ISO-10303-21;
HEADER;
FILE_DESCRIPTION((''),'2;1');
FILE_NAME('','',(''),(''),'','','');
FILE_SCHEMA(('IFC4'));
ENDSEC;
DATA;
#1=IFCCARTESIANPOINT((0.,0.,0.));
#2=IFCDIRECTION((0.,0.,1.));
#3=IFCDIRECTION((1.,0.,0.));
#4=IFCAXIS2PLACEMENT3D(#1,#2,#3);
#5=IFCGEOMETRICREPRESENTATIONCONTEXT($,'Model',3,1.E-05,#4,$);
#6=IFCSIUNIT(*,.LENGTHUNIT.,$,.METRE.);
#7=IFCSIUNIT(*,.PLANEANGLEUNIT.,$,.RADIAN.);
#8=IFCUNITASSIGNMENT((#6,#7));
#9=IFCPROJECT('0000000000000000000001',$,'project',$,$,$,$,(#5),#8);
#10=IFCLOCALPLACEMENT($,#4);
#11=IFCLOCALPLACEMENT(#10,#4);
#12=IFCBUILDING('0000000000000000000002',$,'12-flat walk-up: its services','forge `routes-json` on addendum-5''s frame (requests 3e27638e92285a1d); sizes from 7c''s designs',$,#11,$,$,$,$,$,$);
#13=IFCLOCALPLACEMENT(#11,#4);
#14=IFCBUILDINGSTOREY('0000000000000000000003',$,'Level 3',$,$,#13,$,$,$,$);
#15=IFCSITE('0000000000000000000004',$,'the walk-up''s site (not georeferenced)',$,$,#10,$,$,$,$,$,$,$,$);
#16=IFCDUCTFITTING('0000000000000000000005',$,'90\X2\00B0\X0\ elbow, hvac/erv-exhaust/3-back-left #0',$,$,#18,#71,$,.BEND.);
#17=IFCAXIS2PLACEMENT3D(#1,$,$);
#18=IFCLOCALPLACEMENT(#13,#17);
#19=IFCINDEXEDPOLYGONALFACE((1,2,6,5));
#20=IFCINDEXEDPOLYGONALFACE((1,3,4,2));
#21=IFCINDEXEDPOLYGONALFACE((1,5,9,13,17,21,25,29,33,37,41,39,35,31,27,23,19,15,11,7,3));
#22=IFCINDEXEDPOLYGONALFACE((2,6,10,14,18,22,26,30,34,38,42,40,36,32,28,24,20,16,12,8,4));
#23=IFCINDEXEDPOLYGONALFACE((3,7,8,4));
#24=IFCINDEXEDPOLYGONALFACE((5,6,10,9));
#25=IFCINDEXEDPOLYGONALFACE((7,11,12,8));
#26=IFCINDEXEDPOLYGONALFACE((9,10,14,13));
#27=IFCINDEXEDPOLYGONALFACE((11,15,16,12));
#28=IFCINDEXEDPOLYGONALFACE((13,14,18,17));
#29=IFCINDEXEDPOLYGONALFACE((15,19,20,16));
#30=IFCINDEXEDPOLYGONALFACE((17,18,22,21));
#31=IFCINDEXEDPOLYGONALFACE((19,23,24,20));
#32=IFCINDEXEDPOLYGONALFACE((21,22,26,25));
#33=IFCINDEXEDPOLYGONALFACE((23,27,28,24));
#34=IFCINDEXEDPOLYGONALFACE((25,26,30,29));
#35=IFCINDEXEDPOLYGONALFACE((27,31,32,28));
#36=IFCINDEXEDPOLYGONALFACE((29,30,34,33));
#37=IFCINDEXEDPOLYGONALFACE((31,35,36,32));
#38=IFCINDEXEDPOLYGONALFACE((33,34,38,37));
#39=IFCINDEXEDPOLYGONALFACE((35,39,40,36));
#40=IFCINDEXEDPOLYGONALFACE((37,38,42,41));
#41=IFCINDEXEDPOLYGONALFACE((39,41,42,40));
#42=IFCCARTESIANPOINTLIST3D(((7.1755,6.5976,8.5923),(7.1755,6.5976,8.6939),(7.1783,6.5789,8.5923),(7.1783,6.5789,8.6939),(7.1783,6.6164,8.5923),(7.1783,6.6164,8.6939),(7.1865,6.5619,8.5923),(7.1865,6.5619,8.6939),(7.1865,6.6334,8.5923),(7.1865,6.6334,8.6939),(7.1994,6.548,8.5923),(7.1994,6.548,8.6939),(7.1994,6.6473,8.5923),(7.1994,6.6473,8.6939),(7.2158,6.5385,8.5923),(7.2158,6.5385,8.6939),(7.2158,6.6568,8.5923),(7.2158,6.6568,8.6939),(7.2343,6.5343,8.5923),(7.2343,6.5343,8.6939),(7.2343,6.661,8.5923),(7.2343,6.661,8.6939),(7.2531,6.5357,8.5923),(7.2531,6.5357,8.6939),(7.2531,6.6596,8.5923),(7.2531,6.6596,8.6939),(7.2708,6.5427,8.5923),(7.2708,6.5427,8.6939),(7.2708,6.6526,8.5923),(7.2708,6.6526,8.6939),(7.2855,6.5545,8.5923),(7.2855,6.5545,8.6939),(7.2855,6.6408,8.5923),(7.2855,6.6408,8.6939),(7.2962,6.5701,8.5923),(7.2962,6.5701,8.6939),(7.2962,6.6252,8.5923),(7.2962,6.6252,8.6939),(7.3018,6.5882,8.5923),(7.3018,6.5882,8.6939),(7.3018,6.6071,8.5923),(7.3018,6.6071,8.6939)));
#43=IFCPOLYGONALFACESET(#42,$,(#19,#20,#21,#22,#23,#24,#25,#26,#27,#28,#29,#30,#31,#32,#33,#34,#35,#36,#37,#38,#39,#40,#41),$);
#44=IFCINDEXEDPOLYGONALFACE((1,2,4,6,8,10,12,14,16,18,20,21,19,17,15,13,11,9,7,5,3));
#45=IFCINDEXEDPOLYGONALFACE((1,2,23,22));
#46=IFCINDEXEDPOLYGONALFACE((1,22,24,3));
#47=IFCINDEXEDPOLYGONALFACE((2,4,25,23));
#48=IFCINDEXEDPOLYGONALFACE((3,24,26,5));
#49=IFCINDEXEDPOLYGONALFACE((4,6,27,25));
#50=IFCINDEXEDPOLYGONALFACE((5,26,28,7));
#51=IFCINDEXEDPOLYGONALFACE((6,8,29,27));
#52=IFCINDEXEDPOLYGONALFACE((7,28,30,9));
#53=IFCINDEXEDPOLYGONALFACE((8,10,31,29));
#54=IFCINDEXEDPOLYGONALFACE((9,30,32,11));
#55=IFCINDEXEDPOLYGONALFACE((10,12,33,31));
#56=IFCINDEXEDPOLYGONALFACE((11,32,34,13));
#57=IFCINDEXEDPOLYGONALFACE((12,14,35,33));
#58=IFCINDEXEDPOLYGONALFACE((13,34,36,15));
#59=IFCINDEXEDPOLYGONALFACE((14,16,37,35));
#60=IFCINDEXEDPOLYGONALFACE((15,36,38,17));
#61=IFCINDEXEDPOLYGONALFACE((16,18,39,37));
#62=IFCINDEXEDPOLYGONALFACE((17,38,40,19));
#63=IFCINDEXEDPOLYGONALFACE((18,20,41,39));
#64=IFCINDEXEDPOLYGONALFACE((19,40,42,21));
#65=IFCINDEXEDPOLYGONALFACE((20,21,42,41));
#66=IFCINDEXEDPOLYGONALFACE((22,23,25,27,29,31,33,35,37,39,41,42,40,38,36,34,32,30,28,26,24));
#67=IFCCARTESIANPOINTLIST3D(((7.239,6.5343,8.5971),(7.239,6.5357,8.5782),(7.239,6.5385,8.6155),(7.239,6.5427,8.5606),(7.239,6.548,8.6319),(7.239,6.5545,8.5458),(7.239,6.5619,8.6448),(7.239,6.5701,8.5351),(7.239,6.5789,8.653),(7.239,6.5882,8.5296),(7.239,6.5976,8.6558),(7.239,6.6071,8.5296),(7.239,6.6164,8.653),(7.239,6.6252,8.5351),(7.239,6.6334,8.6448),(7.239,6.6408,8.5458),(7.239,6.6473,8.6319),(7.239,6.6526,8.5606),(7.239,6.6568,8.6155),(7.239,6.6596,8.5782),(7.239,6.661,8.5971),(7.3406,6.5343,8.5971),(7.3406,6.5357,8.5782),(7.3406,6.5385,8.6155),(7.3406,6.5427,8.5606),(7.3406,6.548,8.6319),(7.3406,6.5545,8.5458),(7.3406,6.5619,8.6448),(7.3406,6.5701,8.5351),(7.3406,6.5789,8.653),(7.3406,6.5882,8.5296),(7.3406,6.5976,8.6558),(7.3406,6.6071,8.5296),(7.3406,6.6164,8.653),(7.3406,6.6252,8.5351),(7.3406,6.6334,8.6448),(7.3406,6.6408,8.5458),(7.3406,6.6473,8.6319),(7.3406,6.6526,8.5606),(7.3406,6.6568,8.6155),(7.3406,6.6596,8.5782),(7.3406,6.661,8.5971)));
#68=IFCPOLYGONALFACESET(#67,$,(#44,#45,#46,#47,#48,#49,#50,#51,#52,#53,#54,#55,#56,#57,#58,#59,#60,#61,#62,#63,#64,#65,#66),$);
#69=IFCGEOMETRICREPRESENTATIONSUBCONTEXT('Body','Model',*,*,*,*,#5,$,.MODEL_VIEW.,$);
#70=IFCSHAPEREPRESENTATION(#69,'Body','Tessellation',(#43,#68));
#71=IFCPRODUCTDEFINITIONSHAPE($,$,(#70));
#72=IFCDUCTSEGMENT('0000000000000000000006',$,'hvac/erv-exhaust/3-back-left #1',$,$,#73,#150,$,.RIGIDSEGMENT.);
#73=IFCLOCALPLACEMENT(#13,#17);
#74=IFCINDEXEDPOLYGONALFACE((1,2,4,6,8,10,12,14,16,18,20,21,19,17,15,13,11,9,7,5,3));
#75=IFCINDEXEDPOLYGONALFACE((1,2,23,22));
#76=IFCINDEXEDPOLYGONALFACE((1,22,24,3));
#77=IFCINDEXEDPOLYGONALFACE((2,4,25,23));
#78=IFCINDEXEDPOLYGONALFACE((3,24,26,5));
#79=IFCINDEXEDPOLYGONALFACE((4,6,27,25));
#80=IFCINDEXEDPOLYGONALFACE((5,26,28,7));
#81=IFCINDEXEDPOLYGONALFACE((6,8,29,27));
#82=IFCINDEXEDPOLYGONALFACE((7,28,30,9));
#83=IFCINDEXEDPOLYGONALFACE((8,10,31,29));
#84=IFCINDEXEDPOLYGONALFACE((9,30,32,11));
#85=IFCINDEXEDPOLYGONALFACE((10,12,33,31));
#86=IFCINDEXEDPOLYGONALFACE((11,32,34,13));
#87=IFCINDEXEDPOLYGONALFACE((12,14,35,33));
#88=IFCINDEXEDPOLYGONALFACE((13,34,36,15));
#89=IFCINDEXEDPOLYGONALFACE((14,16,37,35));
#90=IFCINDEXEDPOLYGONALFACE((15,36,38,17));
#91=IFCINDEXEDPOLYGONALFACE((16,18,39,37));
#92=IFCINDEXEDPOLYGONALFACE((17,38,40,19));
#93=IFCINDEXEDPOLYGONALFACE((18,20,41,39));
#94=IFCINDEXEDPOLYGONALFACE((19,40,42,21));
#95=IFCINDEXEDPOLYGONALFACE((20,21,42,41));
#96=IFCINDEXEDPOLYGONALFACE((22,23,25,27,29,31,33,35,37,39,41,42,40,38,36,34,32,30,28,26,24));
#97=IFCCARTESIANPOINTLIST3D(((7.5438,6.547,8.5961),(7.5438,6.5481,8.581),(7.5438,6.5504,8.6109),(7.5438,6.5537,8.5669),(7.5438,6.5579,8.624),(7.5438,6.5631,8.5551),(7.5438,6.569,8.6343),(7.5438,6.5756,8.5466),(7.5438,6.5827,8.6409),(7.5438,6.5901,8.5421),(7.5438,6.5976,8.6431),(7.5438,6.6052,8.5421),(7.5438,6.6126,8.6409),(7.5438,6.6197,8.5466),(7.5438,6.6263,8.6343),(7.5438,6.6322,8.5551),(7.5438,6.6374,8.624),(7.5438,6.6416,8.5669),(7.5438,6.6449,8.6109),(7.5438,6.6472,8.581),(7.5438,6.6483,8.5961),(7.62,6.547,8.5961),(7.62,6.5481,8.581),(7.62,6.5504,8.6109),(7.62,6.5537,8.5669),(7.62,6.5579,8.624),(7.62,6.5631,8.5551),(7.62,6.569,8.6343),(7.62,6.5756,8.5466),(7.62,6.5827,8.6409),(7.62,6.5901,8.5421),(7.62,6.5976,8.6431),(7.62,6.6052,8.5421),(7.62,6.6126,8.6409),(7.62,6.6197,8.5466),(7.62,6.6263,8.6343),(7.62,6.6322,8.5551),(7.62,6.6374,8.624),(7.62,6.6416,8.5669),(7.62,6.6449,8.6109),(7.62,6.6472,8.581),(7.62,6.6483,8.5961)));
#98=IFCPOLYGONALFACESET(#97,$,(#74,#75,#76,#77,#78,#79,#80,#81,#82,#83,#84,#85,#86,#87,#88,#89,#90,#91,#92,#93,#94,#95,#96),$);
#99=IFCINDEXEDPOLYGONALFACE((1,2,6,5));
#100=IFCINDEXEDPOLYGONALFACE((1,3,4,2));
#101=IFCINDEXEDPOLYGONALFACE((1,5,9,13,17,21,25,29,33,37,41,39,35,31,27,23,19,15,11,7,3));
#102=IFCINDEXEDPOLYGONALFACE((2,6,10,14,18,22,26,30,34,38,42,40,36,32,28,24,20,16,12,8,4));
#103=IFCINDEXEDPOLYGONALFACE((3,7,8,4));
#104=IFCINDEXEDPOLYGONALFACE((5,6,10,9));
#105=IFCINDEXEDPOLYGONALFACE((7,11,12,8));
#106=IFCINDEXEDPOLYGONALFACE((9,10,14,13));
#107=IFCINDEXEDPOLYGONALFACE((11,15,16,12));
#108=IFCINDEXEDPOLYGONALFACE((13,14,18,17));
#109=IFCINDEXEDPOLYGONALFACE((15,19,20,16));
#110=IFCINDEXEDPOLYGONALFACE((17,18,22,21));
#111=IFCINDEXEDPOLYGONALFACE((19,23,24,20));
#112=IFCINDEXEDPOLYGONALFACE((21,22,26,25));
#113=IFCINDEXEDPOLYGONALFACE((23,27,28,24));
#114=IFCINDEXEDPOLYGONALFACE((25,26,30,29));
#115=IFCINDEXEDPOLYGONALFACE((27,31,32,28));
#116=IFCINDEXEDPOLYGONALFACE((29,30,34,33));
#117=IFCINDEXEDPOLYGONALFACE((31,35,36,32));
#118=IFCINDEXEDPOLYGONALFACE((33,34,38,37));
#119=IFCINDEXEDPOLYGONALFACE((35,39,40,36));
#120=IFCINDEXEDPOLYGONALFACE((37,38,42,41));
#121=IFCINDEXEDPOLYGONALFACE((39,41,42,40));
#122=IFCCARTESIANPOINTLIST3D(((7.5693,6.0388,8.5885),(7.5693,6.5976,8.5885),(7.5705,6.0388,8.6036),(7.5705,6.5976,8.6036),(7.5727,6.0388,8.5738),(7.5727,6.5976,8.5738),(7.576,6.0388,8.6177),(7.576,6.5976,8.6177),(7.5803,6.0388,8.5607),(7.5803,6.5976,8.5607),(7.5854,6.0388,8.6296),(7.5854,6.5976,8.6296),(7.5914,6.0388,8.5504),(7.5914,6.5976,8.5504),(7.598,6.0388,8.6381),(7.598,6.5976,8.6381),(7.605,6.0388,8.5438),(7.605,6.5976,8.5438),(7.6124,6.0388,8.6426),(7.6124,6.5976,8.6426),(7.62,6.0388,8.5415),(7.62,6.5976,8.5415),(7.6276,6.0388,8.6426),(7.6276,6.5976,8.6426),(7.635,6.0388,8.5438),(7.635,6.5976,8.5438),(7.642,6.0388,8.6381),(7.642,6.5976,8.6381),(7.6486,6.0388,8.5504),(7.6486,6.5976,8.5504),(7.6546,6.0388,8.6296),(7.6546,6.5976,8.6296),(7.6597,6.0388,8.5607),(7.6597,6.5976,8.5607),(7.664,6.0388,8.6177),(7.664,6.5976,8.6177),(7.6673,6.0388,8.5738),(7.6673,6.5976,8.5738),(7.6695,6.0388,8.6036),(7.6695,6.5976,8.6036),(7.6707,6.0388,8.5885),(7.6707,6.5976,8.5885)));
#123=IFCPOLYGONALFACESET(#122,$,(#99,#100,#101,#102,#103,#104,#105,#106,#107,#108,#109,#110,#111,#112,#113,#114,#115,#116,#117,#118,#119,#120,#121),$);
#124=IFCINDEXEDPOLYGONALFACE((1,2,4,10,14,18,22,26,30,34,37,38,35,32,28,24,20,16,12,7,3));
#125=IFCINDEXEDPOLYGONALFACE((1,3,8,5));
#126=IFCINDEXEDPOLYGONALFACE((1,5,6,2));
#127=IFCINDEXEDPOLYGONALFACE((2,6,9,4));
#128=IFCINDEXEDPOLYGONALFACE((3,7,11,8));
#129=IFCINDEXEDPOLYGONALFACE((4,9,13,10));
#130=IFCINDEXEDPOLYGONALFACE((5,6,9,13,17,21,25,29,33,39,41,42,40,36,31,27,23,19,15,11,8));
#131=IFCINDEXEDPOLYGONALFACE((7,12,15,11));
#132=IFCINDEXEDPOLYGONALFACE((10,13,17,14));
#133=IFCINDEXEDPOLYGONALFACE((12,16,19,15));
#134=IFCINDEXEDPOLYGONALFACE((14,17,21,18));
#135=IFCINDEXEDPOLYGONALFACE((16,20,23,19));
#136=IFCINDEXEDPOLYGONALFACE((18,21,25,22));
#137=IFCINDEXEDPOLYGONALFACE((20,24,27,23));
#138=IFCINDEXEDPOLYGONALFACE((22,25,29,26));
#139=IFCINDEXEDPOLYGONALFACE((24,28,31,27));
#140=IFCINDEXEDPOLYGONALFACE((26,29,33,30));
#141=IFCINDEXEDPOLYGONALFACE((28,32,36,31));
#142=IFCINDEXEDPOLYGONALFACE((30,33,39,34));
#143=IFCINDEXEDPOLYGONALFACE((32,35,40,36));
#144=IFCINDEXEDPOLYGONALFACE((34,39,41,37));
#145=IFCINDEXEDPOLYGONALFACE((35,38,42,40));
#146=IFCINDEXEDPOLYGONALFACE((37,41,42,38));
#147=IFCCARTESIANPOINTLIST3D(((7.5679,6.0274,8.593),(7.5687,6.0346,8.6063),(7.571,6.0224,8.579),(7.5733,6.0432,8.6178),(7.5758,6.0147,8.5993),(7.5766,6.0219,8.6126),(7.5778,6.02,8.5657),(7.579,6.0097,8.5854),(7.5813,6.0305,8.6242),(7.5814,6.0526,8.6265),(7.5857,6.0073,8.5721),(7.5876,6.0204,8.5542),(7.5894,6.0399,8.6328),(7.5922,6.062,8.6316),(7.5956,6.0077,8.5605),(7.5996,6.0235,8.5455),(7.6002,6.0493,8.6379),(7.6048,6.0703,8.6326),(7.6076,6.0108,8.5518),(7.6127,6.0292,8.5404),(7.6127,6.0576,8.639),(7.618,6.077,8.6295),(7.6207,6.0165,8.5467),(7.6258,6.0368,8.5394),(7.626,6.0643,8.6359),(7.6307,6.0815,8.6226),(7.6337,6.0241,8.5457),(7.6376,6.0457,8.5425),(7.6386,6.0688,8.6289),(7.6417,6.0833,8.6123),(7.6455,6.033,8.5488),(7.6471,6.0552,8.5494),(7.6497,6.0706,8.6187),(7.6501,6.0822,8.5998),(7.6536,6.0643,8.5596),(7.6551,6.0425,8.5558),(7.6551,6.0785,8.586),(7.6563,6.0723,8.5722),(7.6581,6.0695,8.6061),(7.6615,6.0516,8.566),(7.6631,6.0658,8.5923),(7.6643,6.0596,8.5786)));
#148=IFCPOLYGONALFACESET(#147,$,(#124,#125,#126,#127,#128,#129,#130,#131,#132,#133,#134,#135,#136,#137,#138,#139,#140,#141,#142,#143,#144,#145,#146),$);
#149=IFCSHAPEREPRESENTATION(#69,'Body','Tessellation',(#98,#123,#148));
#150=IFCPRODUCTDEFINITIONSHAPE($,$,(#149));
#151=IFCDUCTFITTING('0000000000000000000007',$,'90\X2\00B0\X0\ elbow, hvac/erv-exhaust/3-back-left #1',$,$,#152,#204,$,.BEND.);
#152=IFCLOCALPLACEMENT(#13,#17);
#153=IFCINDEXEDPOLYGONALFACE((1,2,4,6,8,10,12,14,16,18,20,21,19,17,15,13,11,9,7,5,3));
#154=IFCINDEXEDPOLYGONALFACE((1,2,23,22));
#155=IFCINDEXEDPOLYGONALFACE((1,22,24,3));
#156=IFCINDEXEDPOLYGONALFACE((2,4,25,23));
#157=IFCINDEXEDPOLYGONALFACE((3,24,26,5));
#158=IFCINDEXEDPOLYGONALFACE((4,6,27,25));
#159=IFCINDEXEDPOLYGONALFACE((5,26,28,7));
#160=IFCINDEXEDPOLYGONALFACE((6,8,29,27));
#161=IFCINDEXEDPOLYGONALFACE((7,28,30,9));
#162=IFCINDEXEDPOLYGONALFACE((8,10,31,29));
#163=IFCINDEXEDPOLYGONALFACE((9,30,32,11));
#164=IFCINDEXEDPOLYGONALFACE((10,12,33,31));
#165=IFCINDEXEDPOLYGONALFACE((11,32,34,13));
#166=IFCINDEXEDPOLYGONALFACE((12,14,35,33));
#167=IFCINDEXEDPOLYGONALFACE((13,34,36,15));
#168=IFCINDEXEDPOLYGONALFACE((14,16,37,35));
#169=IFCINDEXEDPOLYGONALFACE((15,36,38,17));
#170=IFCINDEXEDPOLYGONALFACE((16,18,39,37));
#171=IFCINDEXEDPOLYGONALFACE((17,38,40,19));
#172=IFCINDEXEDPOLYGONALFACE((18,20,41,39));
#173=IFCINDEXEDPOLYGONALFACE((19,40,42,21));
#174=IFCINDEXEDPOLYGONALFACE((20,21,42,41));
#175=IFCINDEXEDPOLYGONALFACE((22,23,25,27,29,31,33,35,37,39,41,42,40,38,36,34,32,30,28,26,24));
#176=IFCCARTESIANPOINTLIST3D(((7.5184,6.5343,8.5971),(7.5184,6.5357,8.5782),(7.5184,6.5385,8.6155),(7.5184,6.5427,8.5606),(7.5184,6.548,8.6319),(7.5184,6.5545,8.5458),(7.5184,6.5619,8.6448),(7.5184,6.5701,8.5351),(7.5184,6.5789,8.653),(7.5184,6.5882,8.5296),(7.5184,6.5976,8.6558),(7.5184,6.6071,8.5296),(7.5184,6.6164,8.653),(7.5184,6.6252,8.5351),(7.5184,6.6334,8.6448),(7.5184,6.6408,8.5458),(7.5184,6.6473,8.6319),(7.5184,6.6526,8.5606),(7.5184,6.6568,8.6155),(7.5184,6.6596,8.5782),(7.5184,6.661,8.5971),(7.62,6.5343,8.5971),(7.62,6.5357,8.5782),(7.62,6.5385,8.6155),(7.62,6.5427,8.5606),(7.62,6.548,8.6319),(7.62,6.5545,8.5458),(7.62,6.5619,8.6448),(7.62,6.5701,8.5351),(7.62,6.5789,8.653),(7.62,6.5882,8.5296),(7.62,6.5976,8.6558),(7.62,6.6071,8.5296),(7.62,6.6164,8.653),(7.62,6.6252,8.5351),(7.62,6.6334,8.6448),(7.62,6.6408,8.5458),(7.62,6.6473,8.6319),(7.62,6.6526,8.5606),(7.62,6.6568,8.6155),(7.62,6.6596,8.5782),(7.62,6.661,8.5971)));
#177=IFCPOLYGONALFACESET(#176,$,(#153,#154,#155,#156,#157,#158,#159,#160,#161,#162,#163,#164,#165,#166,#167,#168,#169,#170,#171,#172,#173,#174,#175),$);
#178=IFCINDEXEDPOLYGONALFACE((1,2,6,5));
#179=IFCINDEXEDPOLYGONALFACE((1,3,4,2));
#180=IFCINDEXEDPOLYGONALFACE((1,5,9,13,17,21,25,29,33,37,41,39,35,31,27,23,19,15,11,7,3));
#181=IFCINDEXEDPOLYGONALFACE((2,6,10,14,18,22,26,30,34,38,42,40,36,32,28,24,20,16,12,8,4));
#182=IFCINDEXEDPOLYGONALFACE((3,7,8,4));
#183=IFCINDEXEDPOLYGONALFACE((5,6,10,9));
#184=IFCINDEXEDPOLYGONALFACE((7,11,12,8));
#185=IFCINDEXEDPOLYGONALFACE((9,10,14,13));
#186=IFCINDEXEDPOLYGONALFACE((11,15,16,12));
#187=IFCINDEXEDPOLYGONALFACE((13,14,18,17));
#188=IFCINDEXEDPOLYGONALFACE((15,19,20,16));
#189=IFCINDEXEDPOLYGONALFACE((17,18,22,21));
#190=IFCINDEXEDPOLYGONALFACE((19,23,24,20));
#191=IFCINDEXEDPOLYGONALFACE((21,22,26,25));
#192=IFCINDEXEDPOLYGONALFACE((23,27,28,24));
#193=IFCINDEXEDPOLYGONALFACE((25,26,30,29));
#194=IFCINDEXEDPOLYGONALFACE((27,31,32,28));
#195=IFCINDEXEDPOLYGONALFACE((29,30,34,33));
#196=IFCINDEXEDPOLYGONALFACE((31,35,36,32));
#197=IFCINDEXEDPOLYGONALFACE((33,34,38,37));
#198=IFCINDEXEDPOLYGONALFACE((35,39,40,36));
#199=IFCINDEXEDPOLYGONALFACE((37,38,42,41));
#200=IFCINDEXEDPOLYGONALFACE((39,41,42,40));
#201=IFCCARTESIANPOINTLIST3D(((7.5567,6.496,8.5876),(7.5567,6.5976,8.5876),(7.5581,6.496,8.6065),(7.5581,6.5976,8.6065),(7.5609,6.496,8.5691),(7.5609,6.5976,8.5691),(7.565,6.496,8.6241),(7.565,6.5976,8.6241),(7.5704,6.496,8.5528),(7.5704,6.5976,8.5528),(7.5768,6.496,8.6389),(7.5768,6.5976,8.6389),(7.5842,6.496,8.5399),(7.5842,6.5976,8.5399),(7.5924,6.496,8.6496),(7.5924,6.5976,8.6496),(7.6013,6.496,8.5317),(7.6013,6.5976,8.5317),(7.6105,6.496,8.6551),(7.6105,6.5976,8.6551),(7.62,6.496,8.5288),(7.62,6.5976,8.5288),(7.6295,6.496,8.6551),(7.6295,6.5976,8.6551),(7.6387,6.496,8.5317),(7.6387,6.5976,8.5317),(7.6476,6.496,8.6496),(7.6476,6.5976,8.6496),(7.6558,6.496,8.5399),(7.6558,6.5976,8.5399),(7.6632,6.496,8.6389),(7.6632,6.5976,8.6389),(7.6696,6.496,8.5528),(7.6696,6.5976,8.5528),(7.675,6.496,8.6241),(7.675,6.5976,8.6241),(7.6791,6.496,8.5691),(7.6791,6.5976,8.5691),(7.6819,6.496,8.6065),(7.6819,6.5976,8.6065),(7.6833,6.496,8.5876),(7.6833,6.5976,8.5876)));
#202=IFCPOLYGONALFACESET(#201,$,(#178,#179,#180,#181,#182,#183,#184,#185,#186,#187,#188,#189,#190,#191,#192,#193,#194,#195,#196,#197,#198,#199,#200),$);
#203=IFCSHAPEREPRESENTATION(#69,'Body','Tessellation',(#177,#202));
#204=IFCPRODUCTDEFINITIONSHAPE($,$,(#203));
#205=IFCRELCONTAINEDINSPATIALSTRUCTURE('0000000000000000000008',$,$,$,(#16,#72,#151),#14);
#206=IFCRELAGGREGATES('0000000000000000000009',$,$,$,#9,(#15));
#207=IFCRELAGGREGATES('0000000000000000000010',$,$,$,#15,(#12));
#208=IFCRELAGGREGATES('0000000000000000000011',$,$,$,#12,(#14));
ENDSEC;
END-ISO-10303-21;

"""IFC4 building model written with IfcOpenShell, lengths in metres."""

from ifc_helpers import new_model, entity, si_unit, frame, origin_with_axes, place, context, subcontext, project, spatial, element, save


model = new_model("IFC4")

# Units and contexts
model_context = context("Model", 3, precision=1e-05, world=origin_with_axes())
body_context = subcontext(model_context, "Body", "Model", "MODEL_VIEW")
ifc_project = project(units=[si_unit("LENGTHUNIT", "METRE"), si_unit("PLANEANGLEUNIT", "RADIAN")], contexts=[model_context])

# Site, building, storey
site_placement = place(None, origin_with_axes())
site = spatial("IfcSite", under=ifc_project, at=site_placement, Name="the walk-up's site (not georeferenced)")
building_placement = place(site_placement, origin_with_axes())
building = spatial("IfcBuilding", under=site, at=building_placement, Name="12-flat walk-up: its services", Description="forge `routes-json` on addendum-5's frame (requests 3e27638e92285a1d); sizes from 7c's designs")
storey_placement = place(building_placement, origin_with_axes())
storey = spatial("IfcBuildingStorey", under=building, at=storey_placement, Name="Level 3")

# Duct fitting
duct_fitting_1_placement = place(storey_placement, frame((7.239, 6.5976, 8.6939), z_axis=(0.0, 0.0, 1.0), x_axis=(1.0, 0.0, 0.0)))
element("IfcDuctFitting", 1, at=duct_fitting_1_placement, inside=storey, Name="90° elbow, hvac/erv-exhaust/3-back-left #0", PredefinedType="BEND", context=body_context, shape_type="AdvancedSweptSolid", body=[
    entity("IfcSweptDiskSolid", entity("IfcPolyline", [entity("IfcCartesianPoint", [0.0, 0.0, 0.0]), entity("IfcCartesianPoint", [0.0, 0.0, -0.1016])]), 0.0635),
    entity("IfcSweptDiskSolid", entity("IfcPolyline", [entity("IfcCartesianPoint", [0.0, 0.0, -0.1016]), entity("IfcCartesianPoint", [0.1016, 0.0, -0.1016])]), 0.0635),
])

# Duct segment
duct_segment_1_placement = place(storey_placement, frame((7.5438, 6.5976, 8.5923), z_axis=(0.0, 0.0, 1.0), x_axis=(1.0, 0.0, 0.0)))
element("IfcDuctSegment", 2, at=duct_segment_1_placement, inside=storey, Name="hvac/erv-exhaust/3-back-left #1", PredefinedType="RIGIDSEGMENT", context=body_context, shape_type="AdvancedSweptSolid", body=[
    entity("IfcSweptDiskSolid", entity("IfcPolyline", [entity("IfcCartesianPoint", [0.0, 0.0, 0.0]), entity("IfcCartesianPoint", [0.0762, 0.0, 0.0])]), 0.0508),
    entity("IfcSweptDiskSolid", entity("IfcPolyline", [entity("IfcCartesianPoint", [0.0762, 0.0, 0.0]), entity("IfcCartesianPoint", [0.0762, -0.5588, 0.0])]), 0.0508),
    entity("IfcSweptDiskSolid", entity("IfcPolyline", [entity("IfcCartesianPoint", [0.0762, -0.5588, 0.0]), entity("IfcCartesianPoint", [0.0683, -0.5461, -0.0063])]), 0.0508),
])

# Duct fitting
duct_fitting_2_placement = place(storey_placement, frame((7.5184, 6.5976, 8.5923), z_axis=(0.0, 0.0, 1.0), x_axis=(1.0, 0.0, 0.0)))
element("IfcDuctFitting", 3, at=duct_fitting_2_placement, inside=storey, Name="90° elbow, hvac/erv-exhaust/3-back-left #1", PredefinedType="BEND", context=body_context, shape_type="AdvancedSweptSolid", body=[
    entity("IfcSweptDiskSolid", entity("IfcPolyline", [entity("IfcCartesianPoint", [0.0, 0.0, 0.0]), entity("IfcCartesianPoint", [0.1016, 0.0, 0.0])]), 0.0635),
    entity("IfcSweptDiskSolid", entity("IfcPolyline", [entity("IfcCartesianPoint", [0.1016, 0.0, 0.0]), entity("IfcCartesianPoint", [0.1016, -0.1016, 0.0])]), 0.0635),
])

save(model, "model.ifc")
